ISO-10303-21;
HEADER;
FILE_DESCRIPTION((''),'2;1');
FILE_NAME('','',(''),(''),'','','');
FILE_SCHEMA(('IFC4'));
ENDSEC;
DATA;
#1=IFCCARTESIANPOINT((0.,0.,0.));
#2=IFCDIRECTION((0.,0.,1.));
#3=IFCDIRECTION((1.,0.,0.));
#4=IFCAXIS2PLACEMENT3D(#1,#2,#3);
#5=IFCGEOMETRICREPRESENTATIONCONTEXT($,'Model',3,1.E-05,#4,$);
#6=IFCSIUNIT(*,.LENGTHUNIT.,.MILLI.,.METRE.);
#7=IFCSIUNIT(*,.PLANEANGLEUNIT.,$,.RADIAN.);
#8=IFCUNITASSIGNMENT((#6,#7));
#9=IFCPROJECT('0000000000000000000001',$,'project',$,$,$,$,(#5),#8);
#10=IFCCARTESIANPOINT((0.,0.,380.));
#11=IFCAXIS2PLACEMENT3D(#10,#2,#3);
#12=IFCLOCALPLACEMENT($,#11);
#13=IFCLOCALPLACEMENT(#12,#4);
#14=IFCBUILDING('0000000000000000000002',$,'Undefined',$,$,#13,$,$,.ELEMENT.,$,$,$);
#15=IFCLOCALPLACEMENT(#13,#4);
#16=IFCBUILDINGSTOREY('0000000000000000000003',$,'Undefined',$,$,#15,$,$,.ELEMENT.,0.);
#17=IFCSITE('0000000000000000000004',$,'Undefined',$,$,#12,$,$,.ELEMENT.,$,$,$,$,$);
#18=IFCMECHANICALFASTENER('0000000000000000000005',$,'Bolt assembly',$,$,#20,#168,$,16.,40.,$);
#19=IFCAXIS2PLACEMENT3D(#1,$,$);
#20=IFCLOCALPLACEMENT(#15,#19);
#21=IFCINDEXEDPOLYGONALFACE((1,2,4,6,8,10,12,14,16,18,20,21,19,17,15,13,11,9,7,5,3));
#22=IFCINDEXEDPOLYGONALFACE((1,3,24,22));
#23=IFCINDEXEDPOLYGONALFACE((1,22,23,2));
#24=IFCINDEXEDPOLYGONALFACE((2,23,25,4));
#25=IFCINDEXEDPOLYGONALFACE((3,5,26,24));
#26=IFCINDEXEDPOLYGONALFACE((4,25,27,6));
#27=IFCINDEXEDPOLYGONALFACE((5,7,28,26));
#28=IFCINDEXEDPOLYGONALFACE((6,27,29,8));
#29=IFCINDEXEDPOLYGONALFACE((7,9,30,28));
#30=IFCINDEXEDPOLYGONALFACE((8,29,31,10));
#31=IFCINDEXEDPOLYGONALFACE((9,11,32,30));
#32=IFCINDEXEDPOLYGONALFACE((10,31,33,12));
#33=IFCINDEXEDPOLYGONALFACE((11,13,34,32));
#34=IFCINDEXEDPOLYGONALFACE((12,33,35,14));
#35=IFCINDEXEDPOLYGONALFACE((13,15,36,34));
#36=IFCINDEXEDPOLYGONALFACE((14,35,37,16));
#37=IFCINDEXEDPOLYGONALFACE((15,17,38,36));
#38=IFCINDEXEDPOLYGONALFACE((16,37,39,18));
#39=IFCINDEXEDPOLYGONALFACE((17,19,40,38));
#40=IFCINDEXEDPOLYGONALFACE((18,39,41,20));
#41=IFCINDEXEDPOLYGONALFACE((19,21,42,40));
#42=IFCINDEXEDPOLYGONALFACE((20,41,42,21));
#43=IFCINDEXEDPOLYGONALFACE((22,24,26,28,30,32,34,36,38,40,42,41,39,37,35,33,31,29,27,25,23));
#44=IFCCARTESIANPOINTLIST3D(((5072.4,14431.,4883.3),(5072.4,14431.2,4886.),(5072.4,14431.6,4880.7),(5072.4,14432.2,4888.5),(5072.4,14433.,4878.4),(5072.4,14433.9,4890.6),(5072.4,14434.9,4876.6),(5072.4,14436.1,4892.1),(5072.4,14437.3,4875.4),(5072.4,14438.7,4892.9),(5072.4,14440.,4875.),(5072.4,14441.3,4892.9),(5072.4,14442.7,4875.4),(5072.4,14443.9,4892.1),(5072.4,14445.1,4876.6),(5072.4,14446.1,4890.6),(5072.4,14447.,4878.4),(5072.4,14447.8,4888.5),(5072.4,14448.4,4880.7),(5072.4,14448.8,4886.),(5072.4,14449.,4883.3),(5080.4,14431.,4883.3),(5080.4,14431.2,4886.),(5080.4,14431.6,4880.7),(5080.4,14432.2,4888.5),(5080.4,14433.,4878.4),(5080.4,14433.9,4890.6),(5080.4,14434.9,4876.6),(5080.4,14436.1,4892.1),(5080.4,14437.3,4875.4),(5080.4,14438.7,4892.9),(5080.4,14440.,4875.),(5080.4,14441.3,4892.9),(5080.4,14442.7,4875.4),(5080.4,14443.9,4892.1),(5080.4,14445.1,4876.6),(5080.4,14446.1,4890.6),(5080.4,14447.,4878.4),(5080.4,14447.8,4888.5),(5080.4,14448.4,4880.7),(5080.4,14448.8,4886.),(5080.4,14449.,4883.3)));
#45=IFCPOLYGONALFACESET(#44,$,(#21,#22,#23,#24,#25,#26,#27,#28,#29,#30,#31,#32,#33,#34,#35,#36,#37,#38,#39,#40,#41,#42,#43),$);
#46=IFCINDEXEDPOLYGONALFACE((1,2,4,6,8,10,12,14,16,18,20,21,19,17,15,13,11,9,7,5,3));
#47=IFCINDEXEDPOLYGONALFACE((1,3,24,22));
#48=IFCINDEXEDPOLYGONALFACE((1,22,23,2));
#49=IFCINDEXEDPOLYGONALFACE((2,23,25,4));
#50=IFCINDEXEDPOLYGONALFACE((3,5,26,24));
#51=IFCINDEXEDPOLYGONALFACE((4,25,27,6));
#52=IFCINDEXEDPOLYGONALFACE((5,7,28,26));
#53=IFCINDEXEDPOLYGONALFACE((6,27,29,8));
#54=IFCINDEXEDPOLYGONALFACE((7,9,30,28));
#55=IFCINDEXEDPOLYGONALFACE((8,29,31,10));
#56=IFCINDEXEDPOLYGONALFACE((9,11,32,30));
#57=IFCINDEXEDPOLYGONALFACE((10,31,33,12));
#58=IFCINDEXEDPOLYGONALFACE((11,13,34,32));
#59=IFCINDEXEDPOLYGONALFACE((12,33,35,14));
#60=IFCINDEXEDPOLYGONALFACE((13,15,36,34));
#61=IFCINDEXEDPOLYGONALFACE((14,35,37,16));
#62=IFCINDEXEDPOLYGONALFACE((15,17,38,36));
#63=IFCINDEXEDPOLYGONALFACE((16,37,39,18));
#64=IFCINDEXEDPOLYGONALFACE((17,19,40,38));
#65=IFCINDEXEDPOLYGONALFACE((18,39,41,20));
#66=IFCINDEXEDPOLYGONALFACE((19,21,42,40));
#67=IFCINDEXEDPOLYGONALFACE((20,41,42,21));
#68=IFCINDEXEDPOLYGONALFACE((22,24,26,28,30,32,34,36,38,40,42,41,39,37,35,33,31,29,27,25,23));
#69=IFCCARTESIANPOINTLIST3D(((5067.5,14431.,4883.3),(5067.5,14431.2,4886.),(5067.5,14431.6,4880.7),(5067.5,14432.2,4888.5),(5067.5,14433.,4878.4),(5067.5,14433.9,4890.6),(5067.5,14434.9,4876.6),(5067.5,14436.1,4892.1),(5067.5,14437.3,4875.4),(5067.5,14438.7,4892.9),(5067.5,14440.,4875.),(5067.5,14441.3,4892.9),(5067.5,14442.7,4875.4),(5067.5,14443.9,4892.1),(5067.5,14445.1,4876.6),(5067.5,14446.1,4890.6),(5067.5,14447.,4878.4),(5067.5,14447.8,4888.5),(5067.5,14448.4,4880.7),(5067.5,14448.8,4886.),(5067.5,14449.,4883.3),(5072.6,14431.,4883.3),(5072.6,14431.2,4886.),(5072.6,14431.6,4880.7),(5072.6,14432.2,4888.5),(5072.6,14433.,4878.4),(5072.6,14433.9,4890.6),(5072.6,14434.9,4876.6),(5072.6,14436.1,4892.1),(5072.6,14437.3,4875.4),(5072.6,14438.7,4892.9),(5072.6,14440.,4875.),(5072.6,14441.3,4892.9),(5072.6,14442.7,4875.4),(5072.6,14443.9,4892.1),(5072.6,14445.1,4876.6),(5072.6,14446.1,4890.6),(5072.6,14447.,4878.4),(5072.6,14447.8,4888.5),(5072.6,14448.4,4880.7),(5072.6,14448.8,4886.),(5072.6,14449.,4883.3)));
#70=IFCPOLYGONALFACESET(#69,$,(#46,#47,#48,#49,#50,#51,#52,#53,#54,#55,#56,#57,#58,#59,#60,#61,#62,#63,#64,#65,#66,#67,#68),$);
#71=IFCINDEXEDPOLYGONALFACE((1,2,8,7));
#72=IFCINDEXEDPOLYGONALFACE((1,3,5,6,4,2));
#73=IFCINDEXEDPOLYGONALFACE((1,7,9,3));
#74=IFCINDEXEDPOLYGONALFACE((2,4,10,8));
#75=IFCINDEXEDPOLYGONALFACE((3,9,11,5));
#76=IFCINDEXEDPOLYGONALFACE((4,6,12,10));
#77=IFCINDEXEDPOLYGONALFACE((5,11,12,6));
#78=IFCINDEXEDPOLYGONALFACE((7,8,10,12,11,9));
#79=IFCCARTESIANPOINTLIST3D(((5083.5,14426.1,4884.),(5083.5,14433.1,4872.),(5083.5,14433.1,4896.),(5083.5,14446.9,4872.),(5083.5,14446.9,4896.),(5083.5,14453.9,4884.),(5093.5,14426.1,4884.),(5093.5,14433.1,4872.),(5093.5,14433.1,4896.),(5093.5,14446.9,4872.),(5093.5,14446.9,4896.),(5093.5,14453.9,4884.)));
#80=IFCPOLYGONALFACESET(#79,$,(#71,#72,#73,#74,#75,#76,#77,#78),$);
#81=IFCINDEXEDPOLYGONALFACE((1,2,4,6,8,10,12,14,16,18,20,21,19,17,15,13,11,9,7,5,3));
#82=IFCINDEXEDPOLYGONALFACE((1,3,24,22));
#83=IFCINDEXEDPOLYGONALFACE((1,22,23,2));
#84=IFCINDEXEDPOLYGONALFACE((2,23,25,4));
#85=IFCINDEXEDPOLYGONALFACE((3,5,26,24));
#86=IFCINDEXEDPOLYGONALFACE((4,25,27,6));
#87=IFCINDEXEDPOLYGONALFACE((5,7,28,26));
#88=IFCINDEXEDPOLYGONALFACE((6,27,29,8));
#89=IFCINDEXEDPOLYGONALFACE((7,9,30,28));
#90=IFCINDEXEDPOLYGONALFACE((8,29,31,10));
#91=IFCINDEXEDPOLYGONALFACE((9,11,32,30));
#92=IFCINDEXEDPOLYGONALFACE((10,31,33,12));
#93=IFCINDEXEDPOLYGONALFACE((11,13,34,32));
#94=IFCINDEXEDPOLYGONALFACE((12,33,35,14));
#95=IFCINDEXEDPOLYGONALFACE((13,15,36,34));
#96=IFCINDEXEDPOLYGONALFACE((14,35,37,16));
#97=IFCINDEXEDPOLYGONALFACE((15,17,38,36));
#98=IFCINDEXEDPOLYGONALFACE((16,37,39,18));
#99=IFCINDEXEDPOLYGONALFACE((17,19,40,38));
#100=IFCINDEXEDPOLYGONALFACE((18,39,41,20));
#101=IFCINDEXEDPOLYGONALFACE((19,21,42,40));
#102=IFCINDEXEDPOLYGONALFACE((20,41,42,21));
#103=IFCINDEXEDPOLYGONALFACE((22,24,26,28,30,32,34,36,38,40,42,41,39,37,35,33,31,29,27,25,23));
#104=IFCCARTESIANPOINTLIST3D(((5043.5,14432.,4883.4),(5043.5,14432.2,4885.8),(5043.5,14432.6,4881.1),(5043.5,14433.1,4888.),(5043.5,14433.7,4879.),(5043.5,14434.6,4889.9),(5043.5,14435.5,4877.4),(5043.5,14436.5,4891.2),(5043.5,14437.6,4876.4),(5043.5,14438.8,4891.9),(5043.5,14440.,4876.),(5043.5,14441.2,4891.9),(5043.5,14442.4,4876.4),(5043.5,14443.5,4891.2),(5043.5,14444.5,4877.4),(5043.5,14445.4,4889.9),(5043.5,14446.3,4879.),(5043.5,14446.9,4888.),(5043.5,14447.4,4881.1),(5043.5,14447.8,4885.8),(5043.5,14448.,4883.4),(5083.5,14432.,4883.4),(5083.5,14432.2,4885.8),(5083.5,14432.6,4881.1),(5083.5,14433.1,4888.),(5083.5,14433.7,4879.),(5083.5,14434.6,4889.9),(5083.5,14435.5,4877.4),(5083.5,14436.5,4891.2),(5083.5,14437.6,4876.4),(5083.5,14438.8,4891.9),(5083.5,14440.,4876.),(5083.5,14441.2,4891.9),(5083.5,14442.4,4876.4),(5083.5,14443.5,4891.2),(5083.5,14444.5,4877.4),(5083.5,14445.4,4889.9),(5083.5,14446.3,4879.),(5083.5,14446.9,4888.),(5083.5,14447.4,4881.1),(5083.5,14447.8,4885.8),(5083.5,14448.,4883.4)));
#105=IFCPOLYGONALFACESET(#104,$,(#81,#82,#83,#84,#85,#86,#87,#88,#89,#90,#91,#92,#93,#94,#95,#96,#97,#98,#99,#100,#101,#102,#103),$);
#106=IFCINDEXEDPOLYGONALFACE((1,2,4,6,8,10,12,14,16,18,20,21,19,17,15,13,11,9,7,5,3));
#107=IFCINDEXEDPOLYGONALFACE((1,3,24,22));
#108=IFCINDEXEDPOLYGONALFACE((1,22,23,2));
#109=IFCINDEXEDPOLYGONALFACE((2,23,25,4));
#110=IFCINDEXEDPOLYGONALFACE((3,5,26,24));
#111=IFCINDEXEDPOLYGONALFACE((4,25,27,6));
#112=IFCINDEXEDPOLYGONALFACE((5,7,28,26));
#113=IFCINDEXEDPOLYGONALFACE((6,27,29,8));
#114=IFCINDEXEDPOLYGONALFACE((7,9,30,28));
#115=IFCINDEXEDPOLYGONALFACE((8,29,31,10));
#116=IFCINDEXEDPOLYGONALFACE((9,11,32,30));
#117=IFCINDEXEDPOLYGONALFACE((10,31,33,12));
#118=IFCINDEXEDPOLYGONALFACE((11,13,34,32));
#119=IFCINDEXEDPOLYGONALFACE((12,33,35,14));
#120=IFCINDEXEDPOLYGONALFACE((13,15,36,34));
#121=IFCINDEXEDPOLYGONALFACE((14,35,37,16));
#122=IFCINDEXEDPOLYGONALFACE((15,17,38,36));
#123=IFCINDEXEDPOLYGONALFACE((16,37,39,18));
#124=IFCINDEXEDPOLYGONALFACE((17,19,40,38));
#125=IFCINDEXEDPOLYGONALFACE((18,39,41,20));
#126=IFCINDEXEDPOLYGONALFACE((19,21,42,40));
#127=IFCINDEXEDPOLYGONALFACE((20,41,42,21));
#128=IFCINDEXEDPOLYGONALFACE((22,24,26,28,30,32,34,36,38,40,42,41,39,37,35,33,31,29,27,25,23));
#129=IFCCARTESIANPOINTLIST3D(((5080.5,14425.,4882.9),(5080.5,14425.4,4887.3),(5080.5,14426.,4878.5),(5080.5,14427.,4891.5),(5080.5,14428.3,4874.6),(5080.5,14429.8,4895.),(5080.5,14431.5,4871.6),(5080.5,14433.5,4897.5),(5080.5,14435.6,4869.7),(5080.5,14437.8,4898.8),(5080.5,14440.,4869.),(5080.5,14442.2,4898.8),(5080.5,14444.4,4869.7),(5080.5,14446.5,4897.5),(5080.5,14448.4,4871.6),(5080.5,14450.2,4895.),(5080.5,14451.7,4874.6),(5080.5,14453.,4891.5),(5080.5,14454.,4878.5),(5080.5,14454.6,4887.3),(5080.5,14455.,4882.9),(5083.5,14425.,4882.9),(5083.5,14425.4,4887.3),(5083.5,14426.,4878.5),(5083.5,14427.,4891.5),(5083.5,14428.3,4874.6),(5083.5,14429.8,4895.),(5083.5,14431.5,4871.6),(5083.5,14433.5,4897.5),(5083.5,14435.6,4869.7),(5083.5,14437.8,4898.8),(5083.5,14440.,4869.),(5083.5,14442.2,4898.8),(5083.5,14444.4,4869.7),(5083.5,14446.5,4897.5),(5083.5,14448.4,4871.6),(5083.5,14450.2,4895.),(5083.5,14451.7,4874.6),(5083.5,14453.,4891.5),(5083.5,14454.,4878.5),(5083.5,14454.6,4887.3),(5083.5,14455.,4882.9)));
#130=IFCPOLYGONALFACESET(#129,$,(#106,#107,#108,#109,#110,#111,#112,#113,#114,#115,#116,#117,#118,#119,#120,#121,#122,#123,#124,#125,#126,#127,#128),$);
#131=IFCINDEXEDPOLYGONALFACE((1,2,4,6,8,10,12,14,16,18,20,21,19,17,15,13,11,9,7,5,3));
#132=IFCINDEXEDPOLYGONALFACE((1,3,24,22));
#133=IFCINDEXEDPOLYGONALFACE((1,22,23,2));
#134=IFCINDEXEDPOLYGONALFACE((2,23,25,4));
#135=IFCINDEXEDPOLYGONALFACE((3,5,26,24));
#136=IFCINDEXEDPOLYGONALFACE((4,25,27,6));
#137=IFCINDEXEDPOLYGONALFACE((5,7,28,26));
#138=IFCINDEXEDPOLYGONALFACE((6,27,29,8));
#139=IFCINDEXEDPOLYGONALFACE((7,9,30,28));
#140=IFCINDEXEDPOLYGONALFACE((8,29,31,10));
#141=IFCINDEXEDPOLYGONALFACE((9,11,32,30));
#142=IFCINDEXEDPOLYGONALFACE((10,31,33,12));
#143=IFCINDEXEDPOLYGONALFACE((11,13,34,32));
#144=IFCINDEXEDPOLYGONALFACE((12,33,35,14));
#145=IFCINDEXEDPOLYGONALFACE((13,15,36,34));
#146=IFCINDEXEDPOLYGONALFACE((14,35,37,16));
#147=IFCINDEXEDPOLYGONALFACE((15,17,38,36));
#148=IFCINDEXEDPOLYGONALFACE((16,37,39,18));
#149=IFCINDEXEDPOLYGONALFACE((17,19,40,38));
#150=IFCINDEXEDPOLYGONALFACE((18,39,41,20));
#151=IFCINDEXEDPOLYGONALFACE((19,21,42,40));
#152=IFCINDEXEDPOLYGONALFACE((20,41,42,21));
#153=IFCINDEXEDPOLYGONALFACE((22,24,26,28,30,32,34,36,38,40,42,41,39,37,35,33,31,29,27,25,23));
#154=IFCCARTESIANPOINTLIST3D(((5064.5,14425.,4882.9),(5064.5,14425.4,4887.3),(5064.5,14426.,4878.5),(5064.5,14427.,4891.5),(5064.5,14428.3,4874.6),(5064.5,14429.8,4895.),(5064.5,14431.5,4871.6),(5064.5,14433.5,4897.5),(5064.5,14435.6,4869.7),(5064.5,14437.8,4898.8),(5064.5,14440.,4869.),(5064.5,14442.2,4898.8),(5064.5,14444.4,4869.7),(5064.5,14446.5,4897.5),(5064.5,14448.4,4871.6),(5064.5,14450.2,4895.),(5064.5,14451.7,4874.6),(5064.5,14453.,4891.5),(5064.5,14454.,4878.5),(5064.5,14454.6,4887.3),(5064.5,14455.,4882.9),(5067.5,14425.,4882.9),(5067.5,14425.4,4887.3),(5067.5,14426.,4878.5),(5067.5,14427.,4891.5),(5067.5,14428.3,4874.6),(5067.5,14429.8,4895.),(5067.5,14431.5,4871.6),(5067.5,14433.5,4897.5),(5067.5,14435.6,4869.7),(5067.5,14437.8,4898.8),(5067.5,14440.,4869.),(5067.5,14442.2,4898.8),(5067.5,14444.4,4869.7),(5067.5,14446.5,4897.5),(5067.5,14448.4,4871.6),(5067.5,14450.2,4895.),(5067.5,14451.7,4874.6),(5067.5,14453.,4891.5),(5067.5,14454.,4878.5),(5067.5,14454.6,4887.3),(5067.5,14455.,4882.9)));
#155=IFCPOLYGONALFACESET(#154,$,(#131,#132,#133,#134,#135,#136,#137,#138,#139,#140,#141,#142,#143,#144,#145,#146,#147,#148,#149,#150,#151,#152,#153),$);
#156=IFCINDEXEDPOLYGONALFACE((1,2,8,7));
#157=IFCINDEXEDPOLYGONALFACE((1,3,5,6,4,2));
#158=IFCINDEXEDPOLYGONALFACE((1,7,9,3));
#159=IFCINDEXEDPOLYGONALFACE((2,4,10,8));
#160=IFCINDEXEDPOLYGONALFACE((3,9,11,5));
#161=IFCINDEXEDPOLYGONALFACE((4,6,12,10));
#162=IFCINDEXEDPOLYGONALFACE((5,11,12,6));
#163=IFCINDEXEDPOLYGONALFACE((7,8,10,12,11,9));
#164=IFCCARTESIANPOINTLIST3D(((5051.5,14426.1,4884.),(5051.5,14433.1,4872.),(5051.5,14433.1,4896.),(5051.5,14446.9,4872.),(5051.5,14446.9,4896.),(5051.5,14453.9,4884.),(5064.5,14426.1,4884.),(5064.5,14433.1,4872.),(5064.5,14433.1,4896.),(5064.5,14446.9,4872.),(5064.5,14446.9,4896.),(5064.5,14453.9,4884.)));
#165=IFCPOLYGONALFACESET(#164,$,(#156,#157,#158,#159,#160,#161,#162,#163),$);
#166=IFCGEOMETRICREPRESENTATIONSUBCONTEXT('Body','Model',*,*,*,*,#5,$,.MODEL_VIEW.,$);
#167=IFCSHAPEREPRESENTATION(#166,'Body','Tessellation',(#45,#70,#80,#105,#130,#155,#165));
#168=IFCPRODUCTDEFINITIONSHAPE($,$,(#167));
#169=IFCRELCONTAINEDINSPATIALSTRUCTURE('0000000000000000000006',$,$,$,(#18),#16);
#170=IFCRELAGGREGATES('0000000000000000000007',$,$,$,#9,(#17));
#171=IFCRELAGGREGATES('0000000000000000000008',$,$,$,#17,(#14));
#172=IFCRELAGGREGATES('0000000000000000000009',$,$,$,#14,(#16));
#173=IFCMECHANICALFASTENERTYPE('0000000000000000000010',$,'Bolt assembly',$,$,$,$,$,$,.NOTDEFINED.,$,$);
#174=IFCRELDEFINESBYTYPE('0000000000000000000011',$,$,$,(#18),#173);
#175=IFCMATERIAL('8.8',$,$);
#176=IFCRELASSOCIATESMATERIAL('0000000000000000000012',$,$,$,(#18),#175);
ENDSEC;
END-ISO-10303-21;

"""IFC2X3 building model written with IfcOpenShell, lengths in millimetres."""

from ifc_helpers import new_model, si_unit, frame, origin_with_axes, origin_2d_with_axis, place, context, subcontext, project, spatial, polyline, circle, outline, extrude, source, transform, mapped, material, type_object, element, save


model = new_model("IFC2X3")

# Units and contexts
model_context = context("Model", 3, precision=1e-05, world=origin_with_axes())
body_context = subcontext(model_context, "Body", "Model", "MODEL_VIEW")
ifc_project = project(units=[si_unit("LENGTHUNIT", "METRE", prefix="MILLI"), si_unit("PLANEANGLEUNIT", "RADIAN")], contexts=[model_context])

# Site, building, storey
site_placement = place(None, frame((0.0, 0.0, 380.0), z_axis=(0.0, 0.0, 1.0), x_axis=(1.0, 0.0, 0.0)))
site = spatial("IfcSite", under=ifc_project, at=site_placement, Name="Undefined", CompositionType="ELEMENT")
building_placement = place(site_placement, origin_with_axes())
building = spatial("IfcBuilding", under=site, at=building_placement, Name="Undefined", CompositionType="ELEMENT")
storey_placement = place(building_placement, origin_with_axes())
storey = spatial("IfcBuildingStorey", under=building, at=storey_placement, Name="Undefined", CompositionType="ELEMENT", Elevation=0.0)

# Mechanical fastener
ifc_material_1 = material(Name="8.8")
mechanical_fastener_type = type_object("IfcMechanicalFastenerType", Name="Bolt assembly")
shared_shape_1 = source(origin_with_axes(), body_context, "Body", "SweptSolid", [
    extrude(circle(Radius=9.0, at=origin_2d_with_axis()), frame((0.0, -7.9, 0.0), z_axis=(0.0, 1.0, 0.0), x_axis=(1.0, 0.0, 0.0)), (0.0, 0.0, 1.0), 8.0),
    extrude(circle(Radius=9.0, at=origin_2d_with_axis()), frame((0.0, -0.1, 0.0), z_axis=(0.0, 1.0, 0.0), x_axis=(1.0, 0.0, 0.0)), (0.0, 0.0, 1.0), 5.1),
    extrude(outline(polyline([(12.0, -6.9), (12.0, 6.9), (0.0, 13.9), (-12.0, 6.9), (-12.0, -6.9), (0.0, -13.9), (12.0, -6.9)])), frame((0.0, -21.0, 0.0), z_axis=(0.0, 1.0, 0.0), x_axis=(1.0, 0.0, 0.0)), (0.0, 0.0, 1.0), 10.0),
    extrude(circle(Radius=8.0, at=origin_2d_with_axis()), frame((0.0, -11.0, 0.0), z_axis=(0.0, 1.0, 0.0), x_axis=(1.0, 0.0, 0.0)), (0.0, 0.0, 1.0), 40.0),
    extrude(circle(Radius=15.0, at=origin_2d_with_axis()), frame((0.0, -11.0, 0.0), z_axis=(0.0, 1.0, 0.0), x_axis=(1.0, 0.0, 0.0)), (0.0, 0.0, 1.0), 3.0),
    extrude(circle(Radius=15.0, at=origin_2d_with_axis()), frame((0.0, 5.0, 0.0), z_axis=(0.0, 1.0, 0.0), x_axis=(1.0, 0.0, 0.0)), (0.0, 0.0, 1.0), 3.0),
    extrude(outline(polyline([(12.0, -6.9), (12.0, 6.9), (0.0, 13.9), (-12.0, 6.9), (-12.0, -6.9), (0.0, -13.9), (12.0, -6.9)])), frame((0.0, 8.0, 0.0), z_axis=(0.0, 1.0, 0.0), x_axis=(1.0, 0.0, 0.0)), (0.0, 0.0, 1.0), 13.0),
])
for number, where, z_axis, x_axis, name in (
    (1, (5072.5, 14402.5, 4964.0), (0.0, 1.0, 0.0), (0.0, 0.0, -1.0), "Bolt assembly"),
):
    element("IfcMechanicalFastener", number, at=place(storey_placement, frame(where, z_axis=z_axis, x_axis=x_axis)), inside=storey, type_object=mechanical_fastener_type, material=ifc_material_1, Name=name, NominalDiameter=16.0, NominalLength=40.0, context=body_context, shape_type="MappedRepresentation", body=[
        mapped(shared_shape_1, transform((80.0, 0.0, 37.5))),
    ])

save(model, "model.ifc")
